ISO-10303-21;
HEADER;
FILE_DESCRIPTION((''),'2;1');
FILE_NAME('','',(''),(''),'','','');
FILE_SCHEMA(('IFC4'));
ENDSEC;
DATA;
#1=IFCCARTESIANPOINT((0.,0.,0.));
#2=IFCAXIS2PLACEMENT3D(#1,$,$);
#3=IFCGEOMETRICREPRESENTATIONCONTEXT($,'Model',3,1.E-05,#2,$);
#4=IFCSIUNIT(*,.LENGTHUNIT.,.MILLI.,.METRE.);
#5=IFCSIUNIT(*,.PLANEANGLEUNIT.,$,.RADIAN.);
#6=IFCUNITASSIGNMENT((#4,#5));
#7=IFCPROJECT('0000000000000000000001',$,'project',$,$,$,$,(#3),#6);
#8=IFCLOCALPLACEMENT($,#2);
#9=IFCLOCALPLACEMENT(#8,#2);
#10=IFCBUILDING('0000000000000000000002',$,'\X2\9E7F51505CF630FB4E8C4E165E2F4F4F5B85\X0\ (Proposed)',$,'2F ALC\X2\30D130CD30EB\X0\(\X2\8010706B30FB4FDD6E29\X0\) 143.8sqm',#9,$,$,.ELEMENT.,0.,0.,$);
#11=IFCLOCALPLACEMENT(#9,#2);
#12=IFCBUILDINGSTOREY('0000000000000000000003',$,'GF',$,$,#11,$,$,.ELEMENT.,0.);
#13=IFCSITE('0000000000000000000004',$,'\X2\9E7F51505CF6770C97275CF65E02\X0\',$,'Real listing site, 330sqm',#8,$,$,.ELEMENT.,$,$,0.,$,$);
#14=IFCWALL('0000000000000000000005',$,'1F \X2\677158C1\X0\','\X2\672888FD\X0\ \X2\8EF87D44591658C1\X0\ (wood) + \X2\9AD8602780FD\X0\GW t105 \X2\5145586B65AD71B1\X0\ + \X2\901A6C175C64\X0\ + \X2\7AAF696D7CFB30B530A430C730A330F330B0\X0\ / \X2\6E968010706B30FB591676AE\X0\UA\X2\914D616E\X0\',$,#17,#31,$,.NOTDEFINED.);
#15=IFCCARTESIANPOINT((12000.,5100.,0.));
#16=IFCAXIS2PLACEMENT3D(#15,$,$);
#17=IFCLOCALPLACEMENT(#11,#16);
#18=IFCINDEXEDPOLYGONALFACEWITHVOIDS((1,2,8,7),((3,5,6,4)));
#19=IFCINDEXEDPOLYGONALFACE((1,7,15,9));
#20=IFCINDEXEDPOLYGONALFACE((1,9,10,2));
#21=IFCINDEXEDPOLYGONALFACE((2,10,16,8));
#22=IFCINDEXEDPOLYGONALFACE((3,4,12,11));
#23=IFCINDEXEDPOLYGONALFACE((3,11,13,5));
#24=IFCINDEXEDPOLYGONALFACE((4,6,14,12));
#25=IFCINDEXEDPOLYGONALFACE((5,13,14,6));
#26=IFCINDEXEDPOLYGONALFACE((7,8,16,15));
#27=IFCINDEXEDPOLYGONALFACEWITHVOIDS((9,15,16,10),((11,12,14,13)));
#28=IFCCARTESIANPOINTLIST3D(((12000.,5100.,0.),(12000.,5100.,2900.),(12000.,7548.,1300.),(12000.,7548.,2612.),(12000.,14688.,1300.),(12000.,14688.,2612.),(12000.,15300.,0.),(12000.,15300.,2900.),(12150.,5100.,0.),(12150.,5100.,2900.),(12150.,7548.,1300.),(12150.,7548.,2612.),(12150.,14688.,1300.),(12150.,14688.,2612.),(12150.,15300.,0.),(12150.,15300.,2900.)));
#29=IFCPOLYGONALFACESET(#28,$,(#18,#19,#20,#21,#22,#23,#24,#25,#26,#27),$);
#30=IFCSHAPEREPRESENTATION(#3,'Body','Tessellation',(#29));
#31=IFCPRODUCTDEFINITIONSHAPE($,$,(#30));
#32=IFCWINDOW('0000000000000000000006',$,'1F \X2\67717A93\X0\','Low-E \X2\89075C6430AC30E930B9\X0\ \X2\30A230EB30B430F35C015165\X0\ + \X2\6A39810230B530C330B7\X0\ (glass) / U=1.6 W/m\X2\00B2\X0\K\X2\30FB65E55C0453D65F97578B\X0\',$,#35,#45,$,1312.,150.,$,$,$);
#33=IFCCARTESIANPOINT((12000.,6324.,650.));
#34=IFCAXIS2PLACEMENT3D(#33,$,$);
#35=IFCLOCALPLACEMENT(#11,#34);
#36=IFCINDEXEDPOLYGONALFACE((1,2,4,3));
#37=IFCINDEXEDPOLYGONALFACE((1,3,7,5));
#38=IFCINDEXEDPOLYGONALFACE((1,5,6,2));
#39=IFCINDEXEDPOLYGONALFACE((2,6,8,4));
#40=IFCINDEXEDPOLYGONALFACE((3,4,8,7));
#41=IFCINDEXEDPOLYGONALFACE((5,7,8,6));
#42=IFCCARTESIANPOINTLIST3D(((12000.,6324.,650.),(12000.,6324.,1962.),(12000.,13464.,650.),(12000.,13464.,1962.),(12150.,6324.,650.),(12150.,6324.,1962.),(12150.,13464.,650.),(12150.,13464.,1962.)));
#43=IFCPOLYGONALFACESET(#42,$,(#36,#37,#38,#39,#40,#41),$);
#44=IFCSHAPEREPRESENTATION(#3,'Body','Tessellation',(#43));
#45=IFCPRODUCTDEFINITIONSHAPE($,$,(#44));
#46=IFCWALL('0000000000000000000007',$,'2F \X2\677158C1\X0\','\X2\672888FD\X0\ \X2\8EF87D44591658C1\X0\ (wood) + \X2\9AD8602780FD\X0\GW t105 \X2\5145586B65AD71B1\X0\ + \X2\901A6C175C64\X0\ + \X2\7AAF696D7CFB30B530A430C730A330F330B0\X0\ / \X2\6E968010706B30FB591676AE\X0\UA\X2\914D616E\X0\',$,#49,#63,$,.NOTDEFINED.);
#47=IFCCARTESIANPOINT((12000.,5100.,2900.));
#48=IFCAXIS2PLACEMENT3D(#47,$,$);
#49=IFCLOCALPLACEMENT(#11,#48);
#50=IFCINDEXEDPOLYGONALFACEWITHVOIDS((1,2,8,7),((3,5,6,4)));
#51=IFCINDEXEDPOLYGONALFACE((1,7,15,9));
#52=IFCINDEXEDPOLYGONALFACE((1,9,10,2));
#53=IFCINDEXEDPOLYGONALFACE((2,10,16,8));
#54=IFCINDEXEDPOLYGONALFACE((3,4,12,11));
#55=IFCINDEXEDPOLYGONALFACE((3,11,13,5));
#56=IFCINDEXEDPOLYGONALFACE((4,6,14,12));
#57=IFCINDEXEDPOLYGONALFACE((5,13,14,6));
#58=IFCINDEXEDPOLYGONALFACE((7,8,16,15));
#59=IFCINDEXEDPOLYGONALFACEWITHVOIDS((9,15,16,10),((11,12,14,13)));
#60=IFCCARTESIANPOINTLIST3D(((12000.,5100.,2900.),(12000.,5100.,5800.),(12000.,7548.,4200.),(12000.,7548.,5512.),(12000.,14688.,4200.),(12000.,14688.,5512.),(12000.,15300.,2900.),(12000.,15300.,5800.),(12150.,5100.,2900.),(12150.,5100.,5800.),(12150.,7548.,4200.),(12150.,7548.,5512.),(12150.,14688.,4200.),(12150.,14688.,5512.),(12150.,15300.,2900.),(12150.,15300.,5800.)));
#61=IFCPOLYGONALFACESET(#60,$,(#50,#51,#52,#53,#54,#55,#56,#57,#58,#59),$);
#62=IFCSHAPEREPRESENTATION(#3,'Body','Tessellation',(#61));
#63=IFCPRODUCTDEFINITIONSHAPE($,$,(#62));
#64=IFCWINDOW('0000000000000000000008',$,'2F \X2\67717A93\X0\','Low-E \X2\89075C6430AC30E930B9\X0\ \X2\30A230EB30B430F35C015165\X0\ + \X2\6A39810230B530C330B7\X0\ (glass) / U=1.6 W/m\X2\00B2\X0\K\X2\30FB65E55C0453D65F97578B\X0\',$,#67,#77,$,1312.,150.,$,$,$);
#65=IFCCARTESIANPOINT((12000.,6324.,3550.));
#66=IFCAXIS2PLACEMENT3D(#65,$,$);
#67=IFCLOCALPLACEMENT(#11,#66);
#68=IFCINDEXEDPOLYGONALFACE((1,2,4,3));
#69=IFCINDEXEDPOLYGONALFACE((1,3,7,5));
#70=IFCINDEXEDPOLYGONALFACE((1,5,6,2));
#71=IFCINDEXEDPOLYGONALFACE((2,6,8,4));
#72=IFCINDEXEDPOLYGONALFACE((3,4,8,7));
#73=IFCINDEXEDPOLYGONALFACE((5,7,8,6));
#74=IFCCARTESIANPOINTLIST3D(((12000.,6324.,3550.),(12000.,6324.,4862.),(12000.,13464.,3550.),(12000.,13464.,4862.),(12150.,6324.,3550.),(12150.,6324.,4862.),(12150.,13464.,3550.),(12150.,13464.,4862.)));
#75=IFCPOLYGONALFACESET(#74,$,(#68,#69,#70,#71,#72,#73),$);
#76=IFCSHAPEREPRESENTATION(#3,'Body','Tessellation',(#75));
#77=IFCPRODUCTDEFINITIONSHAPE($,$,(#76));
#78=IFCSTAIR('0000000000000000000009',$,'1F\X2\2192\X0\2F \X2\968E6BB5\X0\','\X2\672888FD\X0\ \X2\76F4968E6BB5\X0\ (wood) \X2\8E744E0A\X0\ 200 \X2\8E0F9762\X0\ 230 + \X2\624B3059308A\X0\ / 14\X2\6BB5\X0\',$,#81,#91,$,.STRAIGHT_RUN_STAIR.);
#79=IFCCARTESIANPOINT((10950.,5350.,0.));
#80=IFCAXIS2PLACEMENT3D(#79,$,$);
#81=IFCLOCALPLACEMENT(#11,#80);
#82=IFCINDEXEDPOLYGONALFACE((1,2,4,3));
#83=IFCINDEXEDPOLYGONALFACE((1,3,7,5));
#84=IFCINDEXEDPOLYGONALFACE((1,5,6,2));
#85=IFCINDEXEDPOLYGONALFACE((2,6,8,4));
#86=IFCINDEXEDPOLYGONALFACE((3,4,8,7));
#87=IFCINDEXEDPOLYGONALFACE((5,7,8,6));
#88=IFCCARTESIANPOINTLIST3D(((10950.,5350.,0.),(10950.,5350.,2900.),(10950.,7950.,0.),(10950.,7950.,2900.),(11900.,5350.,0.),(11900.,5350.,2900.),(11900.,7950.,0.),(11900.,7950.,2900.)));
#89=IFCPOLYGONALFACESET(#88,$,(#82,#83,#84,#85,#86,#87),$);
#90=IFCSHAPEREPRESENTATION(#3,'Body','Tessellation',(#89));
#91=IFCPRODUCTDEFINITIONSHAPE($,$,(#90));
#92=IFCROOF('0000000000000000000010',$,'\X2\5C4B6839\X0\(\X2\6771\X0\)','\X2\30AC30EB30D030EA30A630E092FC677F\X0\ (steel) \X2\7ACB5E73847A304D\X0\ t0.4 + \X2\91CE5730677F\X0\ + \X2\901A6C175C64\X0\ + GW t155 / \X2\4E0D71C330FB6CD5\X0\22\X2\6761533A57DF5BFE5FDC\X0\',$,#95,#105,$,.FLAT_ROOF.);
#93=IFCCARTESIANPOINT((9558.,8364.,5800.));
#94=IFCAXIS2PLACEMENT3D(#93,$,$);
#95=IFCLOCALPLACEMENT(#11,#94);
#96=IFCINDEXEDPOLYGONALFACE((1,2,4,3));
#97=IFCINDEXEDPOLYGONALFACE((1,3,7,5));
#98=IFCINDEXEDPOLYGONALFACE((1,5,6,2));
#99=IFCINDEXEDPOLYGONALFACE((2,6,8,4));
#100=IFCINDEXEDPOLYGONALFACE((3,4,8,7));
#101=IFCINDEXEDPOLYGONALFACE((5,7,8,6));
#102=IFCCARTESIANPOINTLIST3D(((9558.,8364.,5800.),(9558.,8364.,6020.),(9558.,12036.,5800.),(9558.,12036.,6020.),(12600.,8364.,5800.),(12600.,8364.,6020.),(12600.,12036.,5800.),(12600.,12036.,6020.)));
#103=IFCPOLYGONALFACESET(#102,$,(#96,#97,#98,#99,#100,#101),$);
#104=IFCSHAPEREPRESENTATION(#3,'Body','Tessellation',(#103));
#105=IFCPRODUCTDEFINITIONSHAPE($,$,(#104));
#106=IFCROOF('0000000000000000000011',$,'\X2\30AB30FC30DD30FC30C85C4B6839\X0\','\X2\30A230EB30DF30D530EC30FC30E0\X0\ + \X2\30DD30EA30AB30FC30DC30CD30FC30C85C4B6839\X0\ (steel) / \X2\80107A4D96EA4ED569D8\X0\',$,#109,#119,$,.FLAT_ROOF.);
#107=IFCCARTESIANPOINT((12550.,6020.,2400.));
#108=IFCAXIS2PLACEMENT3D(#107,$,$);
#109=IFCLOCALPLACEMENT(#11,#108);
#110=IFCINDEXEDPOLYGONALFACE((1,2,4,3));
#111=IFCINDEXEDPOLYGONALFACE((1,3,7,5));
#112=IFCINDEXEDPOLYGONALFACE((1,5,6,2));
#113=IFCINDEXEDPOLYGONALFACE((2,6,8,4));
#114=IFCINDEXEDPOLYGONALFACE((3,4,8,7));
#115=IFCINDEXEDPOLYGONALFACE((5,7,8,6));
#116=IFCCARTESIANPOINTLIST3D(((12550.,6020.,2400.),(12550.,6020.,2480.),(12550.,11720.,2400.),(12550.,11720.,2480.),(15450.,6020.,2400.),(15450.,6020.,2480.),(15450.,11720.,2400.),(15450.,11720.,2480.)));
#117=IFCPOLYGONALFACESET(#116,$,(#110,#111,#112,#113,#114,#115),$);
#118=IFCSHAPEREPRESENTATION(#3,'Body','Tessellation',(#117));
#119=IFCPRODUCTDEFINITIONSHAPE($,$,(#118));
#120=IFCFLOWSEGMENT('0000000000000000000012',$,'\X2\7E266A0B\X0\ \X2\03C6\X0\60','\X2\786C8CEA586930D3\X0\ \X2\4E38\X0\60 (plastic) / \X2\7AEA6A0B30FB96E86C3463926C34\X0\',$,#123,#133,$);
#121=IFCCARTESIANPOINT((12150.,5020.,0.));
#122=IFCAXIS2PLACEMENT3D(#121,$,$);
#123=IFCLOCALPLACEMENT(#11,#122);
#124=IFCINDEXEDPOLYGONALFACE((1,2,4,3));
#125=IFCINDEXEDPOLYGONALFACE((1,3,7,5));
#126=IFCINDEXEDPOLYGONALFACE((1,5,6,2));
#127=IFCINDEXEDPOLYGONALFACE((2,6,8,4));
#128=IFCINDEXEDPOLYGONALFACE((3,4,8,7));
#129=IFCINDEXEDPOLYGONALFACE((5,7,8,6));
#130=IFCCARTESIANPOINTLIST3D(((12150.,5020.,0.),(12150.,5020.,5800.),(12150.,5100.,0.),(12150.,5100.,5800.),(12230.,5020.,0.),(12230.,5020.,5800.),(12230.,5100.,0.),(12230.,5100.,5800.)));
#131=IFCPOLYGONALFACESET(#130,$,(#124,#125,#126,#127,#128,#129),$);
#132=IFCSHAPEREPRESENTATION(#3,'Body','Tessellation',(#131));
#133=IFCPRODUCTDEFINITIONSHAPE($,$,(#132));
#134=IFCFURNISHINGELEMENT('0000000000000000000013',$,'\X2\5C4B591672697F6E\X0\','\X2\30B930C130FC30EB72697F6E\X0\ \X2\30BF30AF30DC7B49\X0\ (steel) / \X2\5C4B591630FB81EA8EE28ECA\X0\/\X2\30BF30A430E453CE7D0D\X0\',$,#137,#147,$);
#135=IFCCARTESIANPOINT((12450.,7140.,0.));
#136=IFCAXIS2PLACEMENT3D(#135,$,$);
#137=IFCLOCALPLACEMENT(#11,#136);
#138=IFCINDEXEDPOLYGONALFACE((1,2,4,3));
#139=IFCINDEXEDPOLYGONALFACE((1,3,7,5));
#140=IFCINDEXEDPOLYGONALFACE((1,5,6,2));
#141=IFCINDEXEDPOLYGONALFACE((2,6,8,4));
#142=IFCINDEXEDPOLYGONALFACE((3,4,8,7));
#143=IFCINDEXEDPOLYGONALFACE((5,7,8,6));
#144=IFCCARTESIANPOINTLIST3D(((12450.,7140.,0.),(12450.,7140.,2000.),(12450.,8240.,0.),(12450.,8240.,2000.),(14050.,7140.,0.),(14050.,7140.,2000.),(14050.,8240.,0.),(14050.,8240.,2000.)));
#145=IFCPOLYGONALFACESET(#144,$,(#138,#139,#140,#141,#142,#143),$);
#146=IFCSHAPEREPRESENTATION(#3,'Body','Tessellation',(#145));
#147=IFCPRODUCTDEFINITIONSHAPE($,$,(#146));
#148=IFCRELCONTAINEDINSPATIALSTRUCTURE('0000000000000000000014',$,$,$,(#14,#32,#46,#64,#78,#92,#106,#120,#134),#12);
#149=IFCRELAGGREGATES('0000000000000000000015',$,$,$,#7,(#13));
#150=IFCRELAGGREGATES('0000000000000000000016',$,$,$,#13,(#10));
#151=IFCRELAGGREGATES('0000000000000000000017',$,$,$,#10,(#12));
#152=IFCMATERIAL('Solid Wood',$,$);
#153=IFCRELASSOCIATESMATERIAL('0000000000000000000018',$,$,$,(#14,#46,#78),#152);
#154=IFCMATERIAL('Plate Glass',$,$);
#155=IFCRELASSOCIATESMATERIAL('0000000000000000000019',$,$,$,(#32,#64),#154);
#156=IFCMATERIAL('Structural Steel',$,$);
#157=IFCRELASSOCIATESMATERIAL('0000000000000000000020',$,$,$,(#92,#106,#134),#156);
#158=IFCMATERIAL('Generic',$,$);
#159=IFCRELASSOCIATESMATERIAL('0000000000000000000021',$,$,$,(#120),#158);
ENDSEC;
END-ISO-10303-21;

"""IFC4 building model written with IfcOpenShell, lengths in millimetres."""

from ifc_helpers import new_model, si_unit, frame, frame_2d, origin, place, context, project, spatial, rectangle, extrude, material, element, fill, save


model = new_model("IFC4")

# Units and contexts
model_context = context("Model", 3, precision=1e-05, world=origin())
ifc_project = project(units=[si_unit("LENGTHUNIT", "METRE", prefix="MILLI"), si_unit("PLANEANGLEUNIT", "RADIAN")], contexts=[model_context])

# Site, building, storey
site_placement = place(None, origin())
site = spatial("IfcSite", under=ifc_project, at=site_placement, Name="鹿児島県霧島市", ObjectType="Real listing site, 330sqm", CompositionType="ELEMENT", RefElevation=0.0)
building_placement = place(site_placement, origin())
building = spatial("IfcBuilding", under=site, at=building_placement, Name="鹿児島・二世帯住宅 (Proposed)", ObjectType="2F ALCパネル(耐火・保温) 143.8sqm", CompositionType="ELEMENT", ElevationOfRefHeight=0.0, ElevationOfTerrain=0.0)
storey_placement = place(building_placement, origin())
storey = spatial("IfcBuildingStorey", under=building, at=storey_placement, Name="GF", CompositionType="ELEMENT", Elevation=0.0)

# Shared definitions
ifc_material_1 = material(Name="Solid Wood")
ifc_material_2 = material(Name="Structural Steel")

# Walls, openings, windows
wall_1_placement = place(storey_placement, frame((12000.0, 5100.0, 0.0)))
wall_1 = element("IfcWall", 1, at=wall_1_placement, inside=storey, material=ifc_material_1, Name="1F 東壁", Description="木製 軸組外壁 (wood) + 高性能GW t105 充填断熱 + 通気層 + 窯業系サイディング / 準耐火・外皮UA配慮", PredefinedType="NOTDEFINED", context=model_context, shape_type="SweptSolid", body=[
    extrude(rectangle(XDim=150.0, YDim=10200.0, at=frame_2d((75.0, 5100.0))), frame((12000.0, 5100.0, 0.0)), (0.0, 0.0, 1.0), 2900.0),
])
opening_1_placement = place(storey_placement, frame((12000.0, 6324.0, 650.0)))
opening_1 = element("IfcOpeningElement", 2, at=opening_1_placement, cuts=wall_1, PredefinedType="NOTDEFINED", context=model_context, shape_type="SweptSolid", body=[
    extrude(rectangle(XDim=150.0, YDim=7140.0, at=frame_2d((75.0, 3570.0))), frame((12000.0, 6324.0, 650.0)), (0.0, 0.0, 1.0), 1312.0),
])
ifc_material_3 = material(Name="Plate Glass")
window_1_placement = place(storey_placement, frame((12000.0, 6324.0, 650.0)))
window_1 = element("IfcWindow", 3, at=window_1_placement, inside=storey, material=ifc_material_3, Name="1F 東窓", Description="Low-E 複層ガラス アルゴン封入 + 樹脂サッシ (glass) / U=1.6 W/m²K・日射取得型", OverallHeight=1312.0, OverallWidth=150.0, context=model_context, shape_type="SweptSolid", body=[
    extrude(rectangle(XDim=150.0, YDim=7140.0, at=frame_2d((75.0, 3570.0))), frame((12000.0, 6324.0, 650.0)), (0.0, 0.0, 1.0), 1312.0),
])
fill(opening_1, window_1)
wall_2_placement = place(storey_placement, frame((12000.0, 5100.0, 2900.0)))
wall_2 = element("IfcWall", 4, at=wall_2_placement, inside=storey, material=ifc_material_1, Name="2F 東壁", Description="木製 軸組外壁 (wood) + 高性能GW t105 充填断熱 + 通気層 + 窯業系サイディング / 準耐火・外皮UA配慮", PredefinedType="NOTDEFINED", context=model_context, shape_type="SweptSolid", body=[
    extrude(rectangle(XDim=150.0, YDim=10200.0, at=frame_2d((75.0, 5100.0))), frame((12000.0, 5100.0, 2900.0)), (0.0, 0.0, 1.0), 2900.0),
])
opening_2_placement = place(storey_placement, frame((12000.0, 6324.0, 3550.0)))
opening_2 = element("IfcOpeningElement", 5, at=opening_2_placement, cuts=wall_2, PredefinedType="NOTDEFINED", context=model_context, shape_type="SweptSolid", body=[
    extrude(rectangle(XDim=150.0, YDim=7140.0, at=frame_2d((75.0, 3570.0))), frame((12000.0, 6324.0, 3550.0)), (0.0, 0.0, 1.0), 1312.0),
])
window_2_placement = place(storey_placement, frame((12000.0, 6324.0, 3550.0)))
window_2 = element("IfcWindow", 6, at=window_2_placement, inside=storey, material=ifc_material_3, Name="2F 東窓", Description="Low-E 複層ガラス アルゴン封入 + 樹脂サッシ (glass) / U=1.6 W/m²K・日射取得型", OverallHeight=1312.0, OverallWidth=150.0, context=model_context, shape_type="SweptSolid", body=[
    extrude(rectangle(XDim=150.0, YDim=7140.0, at=frame_2d((75.0, 3570.0))), frame((12000.0, 6324.0, 3550.0)), (0.0, 0.0, 1.0), 1312.0),
])
fill(opening_2, window_2)

# Stair
stair_placement = place(storey_placement, frame((10950.0, 5350.0, 0.0)))
element("IfcStair", 7, at=stair_placement, inside=storey, material=ifc_material_1, Name="1F→2F 階段", Description="木製 直階段 (wood) 蹴上 200 踏面 230 + 手すり / 14段", PredefinedType="STRAIGHT_RUN_STAIR", context=model_context, shape_type="SweptSolid", body=[
    extrude(rectangle(XDim=950.0, YDim=2600.0, at=frame_2d((475.0, 1300.0))), frame((10950.0, 5350.0, 0.0)), (0.0, 0.0, 1.0), 2900.0),
])

# Roofs
for number, where, name in (
    (8, (9558.0, 8364.0, 5800.0), "屋根(東)"),
):
    element("IfcRoof", number, at=place(storey_placement, frame(where)), inside=storey, material=ifc_material_2, Name=name, Description="ガルバリウム鋼板 (steel) 立平葺き t0.4 + 野地板 + 通気層 + GW t155 / 不燃・法22条区域対応", PredefinedType="FLAT_ROOF", context=model_context, shape_type="SweptSolid", body=[
        extrude(rectangle(XDim=3042.0, YDim=3672.0, at=frame_2d((1521.0, 1836.0))), frame((9558.0, 8364.0, 5800.0)), (0.0, 0.0, 1.0), 220.0),
    ])
roof_placement = place(storey_placement, frame((12550.0, 6020.0, 2400.0)))
element("IfcRoof", 9, at=roof_placement, inside=storey, material=ifc_material_2, Name="カーポート屋根", Description="アルミフレーム + ポリカーボネート屋根 (steel) / 耐積雪仕様", PredefinedType="FLAT_ROOF", context=model_context, shape_type="SweptSolid", body=[
    extrude(rectangle(XDim=2900.0, YDim=5700.0, at=frame_2d((1450.0, 2850.0))), frame((12550.0, 6020.0, 2400.0)), (0.0, 0.0, 1.0), 80.0),
])

# Flow segment
ifc_material_4 = material(Name="Generic")
flow_segment_placement = place(storey_placement, frame((12150.0, 5020.0, 0.0)))
element("IfcFlowSegment", 10, at=flow_segment_placement, inside=storey, material=ifc_material_4, Name="縦樋 φ60", Description="硬質塩ビ 丸60 (plastic) / 竪樋・雨水排水", context=model_context, shape_type="SweptSolid", body=[
    extrude(rectangle(XDim=80.0, YDim=80.0, at=frame_2d((40.0, 40.0))), frame((12150.0, 5020.0, 0.0)), (0.0, 0.0, 1.0), 5800.0),
])

# Furnishing element
furnishing_placement = place(storey_placement, frame((12450.0, 7140.0, 0.0)))
element("IfcFurnishingElement", 11, at=furnishing_placement, inside=storey, material=ifc_material_2, Name="屋外物置", Description="スチール物置 タクボ等 (steel) / 屋外・自転車/タイヤ収納", context=model_context, shape_type="SweptSolid", body=[
    extrude(rectangle(XDim=1600.0, YDim=1100.0, at=frame_2d((800.0, 550.0))), frame((12450.0, 7140.0, 0.0)), (0.0, 0.0, 1.0), 2000.0),
])

save(model, "model.ifc")
